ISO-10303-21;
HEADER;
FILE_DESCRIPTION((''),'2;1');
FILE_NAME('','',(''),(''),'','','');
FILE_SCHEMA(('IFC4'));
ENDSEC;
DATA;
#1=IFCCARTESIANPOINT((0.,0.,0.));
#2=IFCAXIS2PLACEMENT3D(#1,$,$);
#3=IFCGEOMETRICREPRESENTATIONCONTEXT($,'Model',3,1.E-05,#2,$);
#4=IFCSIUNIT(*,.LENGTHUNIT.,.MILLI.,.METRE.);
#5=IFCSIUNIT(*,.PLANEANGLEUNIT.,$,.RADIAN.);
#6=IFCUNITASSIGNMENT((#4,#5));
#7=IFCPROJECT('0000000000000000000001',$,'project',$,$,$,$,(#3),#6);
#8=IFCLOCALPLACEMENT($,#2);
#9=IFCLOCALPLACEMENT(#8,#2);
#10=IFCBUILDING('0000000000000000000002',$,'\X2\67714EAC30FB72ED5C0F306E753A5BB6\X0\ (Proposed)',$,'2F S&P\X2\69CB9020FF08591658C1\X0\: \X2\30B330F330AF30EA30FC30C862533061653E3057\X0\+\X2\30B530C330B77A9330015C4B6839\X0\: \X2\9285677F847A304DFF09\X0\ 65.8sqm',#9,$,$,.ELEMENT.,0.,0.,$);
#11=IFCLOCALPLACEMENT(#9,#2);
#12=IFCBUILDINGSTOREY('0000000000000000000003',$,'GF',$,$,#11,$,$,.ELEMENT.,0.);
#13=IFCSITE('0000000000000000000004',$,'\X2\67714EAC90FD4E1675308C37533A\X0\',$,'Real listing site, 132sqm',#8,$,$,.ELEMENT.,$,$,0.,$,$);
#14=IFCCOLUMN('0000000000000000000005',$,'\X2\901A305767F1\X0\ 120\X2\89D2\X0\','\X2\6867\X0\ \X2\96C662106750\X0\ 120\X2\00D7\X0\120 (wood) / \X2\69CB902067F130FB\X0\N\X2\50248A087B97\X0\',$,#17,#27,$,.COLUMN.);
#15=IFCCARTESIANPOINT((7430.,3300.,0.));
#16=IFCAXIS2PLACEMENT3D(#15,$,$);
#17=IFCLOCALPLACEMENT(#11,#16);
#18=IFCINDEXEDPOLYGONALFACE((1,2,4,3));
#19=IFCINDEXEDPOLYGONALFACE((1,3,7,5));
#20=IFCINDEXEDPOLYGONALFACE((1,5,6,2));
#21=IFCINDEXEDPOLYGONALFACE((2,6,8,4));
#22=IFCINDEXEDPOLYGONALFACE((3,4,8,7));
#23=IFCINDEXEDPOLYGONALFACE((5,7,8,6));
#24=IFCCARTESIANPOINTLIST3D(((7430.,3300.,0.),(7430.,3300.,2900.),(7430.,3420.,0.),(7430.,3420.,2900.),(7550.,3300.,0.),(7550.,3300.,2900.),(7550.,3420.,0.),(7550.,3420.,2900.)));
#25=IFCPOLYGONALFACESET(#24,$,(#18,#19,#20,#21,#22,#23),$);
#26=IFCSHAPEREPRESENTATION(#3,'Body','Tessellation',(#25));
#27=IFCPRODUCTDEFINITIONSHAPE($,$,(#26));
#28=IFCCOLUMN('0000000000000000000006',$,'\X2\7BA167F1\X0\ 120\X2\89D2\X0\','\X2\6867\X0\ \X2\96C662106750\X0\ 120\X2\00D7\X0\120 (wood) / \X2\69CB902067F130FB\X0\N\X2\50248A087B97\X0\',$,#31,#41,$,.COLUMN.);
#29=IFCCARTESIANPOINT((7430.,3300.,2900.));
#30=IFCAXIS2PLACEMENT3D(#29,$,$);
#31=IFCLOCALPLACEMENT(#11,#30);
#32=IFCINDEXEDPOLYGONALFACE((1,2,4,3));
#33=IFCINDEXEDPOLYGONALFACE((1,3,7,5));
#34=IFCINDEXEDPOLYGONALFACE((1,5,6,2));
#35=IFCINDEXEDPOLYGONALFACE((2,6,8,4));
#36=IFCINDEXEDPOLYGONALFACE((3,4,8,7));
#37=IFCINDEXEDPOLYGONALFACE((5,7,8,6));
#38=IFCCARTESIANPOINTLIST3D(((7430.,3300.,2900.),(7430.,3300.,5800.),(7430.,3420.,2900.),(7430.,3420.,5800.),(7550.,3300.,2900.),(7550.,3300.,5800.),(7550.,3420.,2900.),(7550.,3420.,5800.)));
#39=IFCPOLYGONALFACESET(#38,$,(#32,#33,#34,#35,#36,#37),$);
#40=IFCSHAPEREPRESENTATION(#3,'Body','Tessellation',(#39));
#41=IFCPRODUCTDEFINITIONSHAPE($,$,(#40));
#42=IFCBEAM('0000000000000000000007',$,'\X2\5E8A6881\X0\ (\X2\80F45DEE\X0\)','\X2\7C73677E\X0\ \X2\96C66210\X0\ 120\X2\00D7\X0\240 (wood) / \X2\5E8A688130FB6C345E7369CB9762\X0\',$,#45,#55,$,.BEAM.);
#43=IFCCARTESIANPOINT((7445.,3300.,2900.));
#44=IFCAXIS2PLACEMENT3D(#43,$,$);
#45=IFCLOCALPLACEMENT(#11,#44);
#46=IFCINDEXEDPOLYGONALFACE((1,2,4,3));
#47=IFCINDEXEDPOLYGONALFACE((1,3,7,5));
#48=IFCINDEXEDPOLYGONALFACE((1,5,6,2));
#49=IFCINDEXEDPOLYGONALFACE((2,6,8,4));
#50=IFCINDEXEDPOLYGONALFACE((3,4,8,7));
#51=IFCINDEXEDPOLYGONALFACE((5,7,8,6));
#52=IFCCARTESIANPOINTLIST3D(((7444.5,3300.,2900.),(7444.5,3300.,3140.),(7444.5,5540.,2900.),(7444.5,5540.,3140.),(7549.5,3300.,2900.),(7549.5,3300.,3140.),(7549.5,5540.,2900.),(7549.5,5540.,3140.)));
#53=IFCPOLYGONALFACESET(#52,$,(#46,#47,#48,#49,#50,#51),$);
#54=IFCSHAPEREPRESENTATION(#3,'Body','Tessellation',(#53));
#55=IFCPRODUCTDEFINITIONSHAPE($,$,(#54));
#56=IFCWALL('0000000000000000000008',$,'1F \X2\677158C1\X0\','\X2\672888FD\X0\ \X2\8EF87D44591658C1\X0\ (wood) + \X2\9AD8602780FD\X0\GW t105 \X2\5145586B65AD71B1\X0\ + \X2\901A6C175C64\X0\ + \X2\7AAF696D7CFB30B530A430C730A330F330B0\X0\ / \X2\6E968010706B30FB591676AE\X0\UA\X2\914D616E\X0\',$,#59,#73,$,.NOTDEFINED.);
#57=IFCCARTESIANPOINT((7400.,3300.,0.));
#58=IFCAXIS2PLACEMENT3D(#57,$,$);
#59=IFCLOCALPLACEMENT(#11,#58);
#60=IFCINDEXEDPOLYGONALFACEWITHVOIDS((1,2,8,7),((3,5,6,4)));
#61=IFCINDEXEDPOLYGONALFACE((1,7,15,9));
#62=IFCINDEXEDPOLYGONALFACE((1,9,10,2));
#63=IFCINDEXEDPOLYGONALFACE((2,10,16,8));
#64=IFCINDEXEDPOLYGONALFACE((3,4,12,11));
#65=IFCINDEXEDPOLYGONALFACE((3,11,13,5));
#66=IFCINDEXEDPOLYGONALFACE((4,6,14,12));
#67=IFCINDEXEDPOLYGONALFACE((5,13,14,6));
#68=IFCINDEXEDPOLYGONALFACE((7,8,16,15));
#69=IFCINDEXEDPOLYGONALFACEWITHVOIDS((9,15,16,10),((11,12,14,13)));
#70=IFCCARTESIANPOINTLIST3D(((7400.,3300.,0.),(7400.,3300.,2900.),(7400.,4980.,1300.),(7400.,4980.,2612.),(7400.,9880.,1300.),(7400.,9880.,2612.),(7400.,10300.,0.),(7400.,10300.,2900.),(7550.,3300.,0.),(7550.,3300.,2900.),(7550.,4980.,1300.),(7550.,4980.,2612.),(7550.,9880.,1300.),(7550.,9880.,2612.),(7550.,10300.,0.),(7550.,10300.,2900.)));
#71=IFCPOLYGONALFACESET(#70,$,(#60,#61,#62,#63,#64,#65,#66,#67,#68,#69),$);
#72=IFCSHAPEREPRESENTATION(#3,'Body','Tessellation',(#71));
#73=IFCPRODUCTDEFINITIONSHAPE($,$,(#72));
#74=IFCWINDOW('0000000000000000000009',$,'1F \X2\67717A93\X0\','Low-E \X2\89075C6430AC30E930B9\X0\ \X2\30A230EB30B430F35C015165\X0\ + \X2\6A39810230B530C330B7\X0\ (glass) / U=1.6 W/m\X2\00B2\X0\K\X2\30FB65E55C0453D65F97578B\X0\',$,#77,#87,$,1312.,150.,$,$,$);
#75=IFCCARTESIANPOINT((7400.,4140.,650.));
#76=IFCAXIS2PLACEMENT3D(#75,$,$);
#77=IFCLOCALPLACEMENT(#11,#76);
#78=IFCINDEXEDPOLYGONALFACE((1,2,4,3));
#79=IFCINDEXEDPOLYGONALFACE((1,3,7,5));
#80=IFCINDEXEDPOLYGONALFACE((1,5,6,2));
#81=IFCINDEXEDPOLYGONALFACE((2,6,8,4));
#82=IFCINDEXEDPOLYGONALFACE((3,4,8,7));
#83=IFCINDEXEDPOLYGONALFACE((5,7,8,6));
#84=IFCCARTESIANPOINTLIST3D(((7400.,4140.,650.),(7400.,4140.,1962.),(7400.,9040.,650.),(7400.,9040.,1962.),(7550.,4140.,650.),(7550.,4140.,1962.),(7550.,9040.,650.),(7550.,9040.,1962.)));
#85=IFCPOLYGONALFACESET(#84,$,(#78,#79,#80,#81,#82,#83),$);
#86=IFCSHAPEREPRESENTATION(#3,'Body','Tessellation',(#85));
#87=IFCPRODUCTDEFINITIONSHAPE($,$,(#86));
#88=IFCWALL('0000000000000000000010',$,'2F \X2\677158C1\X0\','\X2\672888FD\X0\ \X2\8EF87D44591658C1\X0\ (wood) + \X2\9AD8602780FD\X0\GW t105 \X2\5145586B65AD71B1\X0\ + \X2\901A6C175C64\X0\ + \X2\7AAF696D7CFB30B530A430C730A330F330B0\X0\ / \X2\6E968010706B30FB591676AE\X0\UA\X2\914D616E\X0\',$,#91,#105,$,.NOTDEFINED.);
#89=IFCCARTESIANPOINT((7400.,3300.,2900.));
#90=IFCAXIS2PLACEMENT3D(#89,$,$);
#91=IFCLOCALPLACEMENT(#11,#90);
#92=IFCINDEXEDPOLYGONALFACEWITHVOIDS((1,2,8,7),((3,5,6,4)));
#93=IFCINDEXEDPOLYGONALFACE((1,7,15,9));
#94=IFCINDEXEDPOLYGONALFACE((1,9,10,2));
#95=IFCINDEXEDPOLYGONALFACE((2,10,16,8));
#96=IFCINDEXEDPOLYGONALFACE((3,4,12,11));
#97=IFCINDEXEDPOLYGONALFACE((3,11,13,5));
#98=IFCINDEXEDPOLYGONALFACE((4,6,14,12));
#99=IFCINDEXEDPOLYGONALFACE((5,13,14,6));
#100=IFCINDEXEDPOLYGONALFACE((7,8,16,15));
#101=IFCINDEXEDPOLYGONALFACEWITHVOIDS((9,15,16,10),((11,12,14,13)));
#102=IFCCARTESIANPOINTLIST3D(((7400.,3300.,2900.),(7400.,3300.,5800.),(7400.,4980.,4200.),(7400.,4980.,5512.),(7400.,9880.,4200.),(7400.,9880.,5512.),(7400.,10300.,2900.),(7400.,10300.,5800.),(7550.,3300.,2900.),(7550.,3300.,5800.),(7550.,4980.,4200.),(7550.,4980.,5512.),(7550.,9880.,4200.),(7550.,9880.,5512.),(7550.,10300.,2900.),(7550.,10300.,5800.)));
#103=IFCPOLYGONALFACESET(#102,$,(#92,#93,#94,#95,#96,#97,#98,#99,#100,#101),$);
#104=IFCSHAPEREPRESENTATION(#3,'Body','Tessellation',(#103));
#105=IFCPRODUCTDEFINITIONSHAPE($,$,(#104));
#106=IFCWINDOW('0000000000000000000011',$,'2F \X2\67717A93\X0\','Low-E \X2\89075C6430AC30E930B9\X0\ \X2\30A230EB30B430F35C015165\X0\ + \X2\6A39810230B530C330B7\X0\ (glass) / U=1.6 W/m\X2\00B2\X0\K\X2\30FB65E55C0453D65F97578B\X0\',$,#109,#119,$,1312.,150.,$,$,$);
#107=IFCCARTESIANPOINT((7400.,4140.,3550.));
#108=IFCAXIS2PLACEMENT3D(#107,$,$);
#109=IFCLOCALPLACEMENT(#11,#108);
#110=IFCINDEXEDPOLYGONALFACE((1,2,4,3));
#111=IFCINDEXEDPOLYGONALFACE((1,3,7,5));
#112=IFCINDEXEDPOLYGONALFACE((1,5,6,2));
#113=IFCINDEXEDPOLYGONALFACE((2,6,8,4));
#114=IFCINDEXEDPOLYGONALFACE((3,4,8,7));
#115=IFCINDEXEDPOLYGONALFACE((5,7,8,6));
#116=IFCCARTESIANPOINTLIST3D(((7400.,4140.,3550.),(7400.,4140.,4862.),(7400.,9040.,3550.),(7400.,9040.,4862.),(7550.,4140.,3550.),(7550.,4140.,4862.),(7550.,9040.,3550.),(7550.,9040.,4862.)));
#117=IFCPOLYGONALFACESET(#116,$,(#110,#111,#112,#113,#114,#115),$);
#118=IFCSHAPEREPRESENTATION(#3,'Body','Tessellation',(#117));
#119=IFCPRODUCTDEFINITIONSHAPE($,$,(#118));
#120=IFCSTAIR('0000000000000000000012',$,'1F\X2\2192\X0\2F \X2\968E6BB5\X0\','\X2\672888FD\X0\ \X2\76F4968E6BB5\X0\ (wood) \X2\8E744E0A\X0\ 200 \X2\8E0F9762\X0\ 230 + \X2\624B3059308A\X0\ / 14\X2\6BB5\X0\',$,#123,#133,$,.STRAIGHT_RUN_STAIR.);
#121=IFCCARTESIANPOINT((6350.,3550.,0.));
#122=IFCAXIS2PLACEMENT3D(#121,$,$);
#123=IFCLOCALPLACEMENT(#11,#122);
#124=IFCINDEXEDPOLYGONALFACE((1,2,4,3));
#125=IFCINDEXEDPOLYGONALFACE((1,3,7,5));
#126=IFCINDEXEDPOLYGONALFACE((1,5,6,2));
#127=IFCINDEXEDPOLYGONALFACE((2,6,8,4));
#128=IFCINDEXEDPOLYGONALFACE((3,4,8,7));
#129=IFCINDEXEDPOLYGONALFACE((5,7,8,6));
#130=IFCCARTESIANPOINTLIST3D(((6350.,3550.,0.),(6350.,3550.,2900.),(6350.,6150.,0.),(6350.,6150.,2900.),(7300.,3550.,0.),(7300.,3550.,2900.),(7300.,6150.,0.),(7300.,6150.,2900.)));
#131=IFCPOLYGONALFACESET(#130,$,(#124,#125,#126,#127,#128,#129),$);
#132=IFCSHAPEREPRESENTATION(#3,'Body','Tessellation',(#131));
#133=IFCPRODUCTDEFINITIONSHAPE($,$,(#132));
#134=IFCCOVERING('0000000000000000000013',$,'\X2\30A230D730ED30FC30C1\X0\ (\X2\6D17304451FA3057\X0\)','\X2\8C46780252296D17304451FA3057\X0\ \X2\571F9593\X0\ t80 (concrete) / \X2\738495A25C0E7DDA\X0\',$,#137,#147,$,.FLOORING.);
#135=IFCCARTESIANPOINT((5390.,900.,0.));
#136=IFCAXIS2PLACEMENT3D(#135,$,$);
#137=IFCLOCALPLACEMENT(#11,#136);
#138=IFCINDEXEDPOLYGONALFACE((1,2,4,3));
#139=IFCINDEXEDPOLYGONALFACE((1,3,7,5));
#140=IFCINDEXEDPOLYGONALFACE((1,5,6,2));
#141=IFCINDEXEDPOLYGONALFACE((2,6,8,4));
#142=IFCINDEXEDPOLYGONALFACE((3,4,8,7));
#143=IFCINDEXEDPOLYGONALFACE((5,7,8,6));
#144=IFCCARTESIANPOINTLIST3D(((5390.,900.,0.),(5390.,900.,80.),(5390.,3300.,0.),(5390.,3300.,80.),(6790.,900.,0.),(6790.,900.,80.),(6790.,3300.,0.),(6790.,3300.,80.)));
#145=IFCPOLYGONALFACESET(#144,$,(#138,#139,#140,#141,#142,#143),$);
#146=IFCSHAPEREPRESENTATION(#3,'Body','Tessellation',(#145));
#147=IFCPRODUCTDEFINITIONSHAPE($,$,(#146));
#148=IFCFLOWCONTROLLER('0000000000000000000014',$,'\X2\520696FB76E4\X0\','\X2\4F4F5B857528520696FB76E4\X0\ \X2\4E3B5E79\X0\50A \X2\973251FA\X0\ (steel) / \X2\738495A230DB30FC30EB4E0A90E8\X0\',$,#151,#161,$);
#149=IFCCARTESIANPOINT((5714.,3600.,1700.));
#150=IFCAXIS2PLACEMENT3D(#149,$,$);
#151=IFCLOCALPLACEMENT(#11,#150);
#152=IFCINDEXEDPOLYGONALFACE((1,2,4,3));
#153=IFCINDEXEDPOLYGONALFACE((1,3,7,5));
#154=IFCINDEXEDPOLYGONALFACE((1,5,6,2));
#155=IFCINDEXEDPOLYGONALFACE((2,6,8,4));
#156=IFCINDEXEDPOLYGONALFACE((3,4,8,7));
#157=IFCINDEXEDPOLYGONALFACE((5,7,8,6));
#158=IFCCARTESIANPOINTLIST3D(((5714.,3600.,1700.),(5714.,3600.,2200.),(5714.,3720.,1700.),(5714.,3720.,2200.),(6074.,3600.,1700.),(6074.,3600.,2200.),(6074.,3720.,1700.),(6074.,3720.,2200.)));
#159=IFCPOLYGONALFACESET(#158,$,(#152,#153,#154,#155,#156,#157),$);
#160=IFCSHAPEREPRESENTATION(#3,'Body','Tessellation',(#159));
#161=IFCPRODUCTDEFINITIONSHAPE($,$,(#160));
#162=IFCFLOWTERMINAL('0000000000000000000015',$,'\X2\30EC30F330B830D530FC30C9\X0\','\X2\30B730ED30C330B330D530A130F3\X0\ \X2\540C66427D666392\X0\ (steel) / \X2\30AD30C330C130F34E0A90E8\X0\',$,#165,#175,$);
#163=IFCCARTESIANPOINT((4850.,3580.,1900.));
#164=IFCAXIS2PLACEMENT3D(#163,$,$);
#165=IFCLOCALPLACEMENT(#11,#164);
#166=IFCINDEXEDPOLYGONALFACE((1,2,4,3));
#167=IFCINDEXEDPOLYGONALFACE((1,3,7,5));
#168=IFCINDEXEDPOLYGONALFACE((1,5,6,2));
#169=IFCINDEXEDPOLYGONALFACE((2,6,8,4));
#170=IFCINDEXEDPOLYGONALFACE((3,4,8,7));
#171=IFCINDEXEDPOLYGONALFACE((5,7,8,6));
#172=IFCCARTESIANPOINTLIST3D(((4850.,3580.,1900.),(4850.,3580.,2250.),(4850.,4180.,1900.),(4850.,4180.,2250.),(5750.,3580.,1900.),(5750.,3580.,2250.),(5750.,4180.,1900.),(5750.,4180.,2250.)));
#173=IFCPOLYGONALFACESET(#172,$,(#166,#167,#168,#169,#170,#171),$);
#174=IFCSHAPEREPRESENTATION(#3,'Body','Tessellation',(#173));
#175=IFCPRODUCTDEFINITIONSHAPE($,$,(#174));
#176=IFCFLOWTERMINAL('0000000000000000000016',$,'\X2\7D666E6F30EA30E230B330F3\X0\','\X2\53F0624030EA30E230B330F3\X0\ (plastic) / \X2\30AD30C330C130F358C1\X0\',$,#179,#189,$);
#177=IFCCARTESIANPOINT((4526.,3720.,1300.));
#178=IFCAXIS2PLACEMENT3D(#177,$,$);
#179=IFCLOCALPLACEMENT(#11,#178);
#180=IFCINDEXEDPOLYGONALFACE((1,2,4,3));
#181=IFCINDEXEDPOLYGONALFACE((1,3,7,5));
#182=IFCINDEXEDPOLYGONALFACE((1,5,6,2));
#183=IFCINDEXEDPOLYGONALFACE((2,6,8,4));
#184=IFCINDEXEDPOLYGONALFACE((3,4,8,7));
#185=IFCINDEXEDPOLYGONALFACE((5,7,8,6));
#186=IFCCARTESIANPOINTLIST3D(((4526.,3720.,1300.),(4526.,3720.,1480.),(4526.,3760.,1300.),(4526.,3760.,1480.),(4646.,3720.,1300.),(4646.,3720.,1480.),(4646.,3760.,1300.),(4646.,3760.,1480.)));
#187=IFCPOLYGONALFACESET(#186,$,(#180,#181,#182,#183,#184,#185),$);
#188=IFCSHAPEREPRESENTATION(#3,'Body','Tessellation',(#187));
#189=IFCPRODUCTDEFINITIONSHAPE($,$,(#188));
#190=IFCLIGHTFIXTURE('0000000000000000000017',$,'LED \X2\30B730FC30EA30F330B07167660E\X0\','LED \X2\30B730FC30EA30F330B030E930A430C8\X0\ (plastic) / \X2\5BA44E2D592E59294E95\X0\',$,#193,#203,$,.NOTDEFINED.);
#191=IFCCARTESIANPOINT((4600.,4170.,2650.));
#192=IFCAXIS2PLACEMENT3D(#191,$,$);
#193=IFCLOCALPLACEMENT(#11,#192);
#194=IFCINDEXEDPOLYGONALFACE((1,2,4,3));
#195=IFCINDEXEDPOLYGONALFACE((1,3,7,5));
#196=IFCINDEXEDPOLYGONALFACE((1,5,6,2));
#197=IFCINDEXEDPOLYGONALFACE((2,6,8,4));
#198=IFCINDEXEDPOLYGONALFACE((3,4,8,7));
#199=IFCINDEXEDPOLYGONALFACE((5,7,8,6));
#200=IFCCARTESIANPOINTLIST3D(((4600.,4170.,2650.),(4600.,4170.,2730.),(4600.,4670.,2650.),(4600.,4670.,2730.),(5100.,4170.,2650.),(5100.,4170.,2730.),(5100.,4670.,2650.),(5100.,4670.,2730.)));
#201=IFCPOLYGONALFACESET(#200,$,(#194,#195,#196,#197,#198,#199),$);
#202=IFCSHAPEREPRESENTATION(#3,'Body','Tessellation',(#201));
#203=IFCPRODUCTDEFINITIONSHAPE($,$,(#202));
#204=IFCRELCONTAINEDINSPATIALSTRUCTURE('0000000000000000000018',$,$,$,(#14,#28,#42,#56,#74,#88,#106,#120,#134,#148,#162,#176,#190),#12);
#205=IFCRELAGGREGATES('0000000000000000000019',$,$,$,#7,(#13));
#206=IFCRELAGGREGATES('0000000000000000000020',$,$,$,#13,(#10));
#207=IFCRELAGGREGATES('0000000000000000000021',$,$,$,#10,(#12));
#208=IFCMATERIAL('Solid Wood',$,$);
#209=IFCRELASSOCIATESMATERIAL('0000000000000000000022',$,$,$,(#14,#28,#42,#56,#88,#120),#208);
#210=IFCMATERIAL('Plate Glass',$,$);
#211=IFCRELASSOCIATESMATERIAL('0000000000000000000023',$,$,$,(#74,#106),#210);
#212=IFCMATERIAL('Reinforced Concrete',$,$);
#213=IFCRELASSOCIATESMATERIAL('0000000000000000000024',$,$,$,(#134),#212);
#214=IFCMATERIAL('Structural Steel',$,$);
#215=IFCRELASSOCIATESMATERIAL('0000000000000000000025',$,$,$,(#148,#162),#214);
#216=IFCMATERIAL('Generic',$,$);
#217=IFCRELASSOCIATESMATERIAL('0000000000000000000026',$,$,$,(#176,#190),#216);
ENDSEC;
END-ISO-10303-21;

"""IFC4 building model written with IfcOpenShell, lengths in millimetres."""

from ifc_helpers import new_model, si_unit, frame, frame_2d, origin, place, context, project, spatial, rectangle, extrude, material, element, fill, save


model = new_model("IFC4")

# Units and contexts
model_context = context("Model", 3, precision=1e-05, world=origin())
ifc_project = project(units=[si_unit("LENGTHUNIT", "METRE", prefix="MILLI"), si_unit("PLANEANGLEUNIT", "RADIAN")], contexts=[model_context])

# Site, building, storey
site_placement = place(None, origin())
site = spatial("IfcSite", under=ifc_project, at=site_placement, Name="東京都世田谷区", ObjectType="Real listing site, 132sqm", CompositionType="ELEMENT", RefElevation=0.0)
building_placement = place(site_placement, origin())
building = spatial("IfcBuilding", under=site, at=building_placement, Name="東京・狭小の町家 (Proposed)", ObjectType="2F S&P構造（外壁: コンクリート打ち放し+サッシ窓、屋根: 銅板葺き） 65.8sqm", CompositionType="ELEMENT", ElevationOfRefHeight=0.0, ElevationOfTerrain=0.0)
storey_placement = place(building_placement, origin())
storey = spatial("IfcBuildingStorey", under=building, at=storey_placement, Name="GF", CompositionType="ELEMENT", Elevation=0.0)

# Columns
ifc_material_1 = material(Name="Solid Wood")
column_1_placement = place(storey_placement, frame((7430.0, 3300.0, 0.0)))
element("IfcColumn", 1, at=column_1_placement, inside=storey, material=ifc_material_1, Name="通し柱 120角", Description="桧 集成材 120×120 (wood) / 構造柱・N値計算", PredefinedType="COLUMN", context=model_context, shape_type="SweptSolid", body=[
    extrude(rectangle(XDim=120.0, YDim=120.0, at=frame_2d((60.0, 60.0))), frame((7430.0, 3300.0, 0.0)), (0.0, 0.0, 1.0), 2900.0),
])
column_2_placement = place(storey_placement, frame((7430.0, 3300.0, 2900.0)))
element("IfcColumn", 2, at=column_2_placement, inside=storey, material=ifc_material_1, Name="管柱 120角", Description="桧 集成材 120×120 (wood) / 構造柱・N値計算", PredefinedType="COLUMN", context=model_context, shape_type="SweptSolid", body=[
    extrude(rectangle(XDim=120.0, YDim=120.0, at=frame_2d((60.0, 60.0))), frame((7430.0, 3300.0, 2900.0)), (0.0, 0.0, 1.0), 2900.0),
])

# Beam
beam_1_placement = place(storey_placement, frame((7445.0, 3300.0, 2900.0)))
element("IfcBeam", 3, at=beam_1_placement, inside=storey, material=ifc_material_1, Name="床梁 (胴差)", Description="米松 集成 120×240 (wood) / 床梁・水平構面", PredefinedType="BEAM", context=model_context, shape_type="SweptSolid", body=[
    extrude(rectangle(XDim=105.0, YDim=2240.0, at=frame_2d((52.0, 1120.0))), frame((7445.0, 3300.0, 2900.0)), (0.0, 0.0, 1.0), 240.0),
])

# Wall, opening, window
wall_1_placement = place(storey_placement, frame((7400.0, 3300.0, 0.0)))
wall_1 = element("IfcWall", 4, at=wall_1_placement, inside=storey, material=ifc_material_1, Name="1F 東壁", Description="木製 軸組外壁 (wood) + 高性能GW t105 充填断熱 + 通気層 + 窯業系サイディング / 準耐火・外皮UA配慮", PredefinedType="NOTDEFINED", context=model_context, shape_type="SweptSolid", body=[
    extrude(rectangle(XDim=150.0, YDim=7000.0, at=frame_2d((75.0, 3500.0))), frame((7400.0, 3300.0, 0.0)), (0.0, 0.0, 1.0), 2900.0),
])
opening_1_placement = place(storey_placement, frame((7400.0, 4140.0, 650.0)))
opening_1 = element("IfcOpeningElement", 5, at=opening_1_placement, cuts=wall_1, PredefinedType="NOTDEFINED", context=model_context, shape_type="SweptSolid", body=[
    extrude(rectangle(XDim=150.0, YDim=4900.0, at=frame_2d((75.0, 2450.0))), frame((7400.0, 4140.0, 650.0)), (0.0, 0.0, 1.0), 1312.0),
])
ifc_material_2 = material(Name="Plate Glass")
window_1_placement = place(storey_placement, frame((7400.0, 4140.0, 650.0)))
window_1 = element("IfcWindow", 6, at=window_1_placement, inside=storey, material=ifc_material_2, Name="1F 東窓", Description="Low-E 複層ガラス アルゴン封入 + 樹脂サッシ (glass) / U=1.6 W/m²K・日射取得型", OverallHeight=1312.0, OverallWidth=150.0, context=model_context, shape_type="SweptSolid", body=[
    extrude(rectangle(XDim=150.0, YDim=4900.0, at=frame_2d((75.0, 2450.0))), frame((7400.0, 4140.0, 650.0)), (0.0, 0.0, 1.0), 1312.0),
])
fill(opening_1, window_1)

# Wall, opening, window
wall_2_placement = place(storey_placement, frame((7400.0, 3300.0, 2900.0)))
wall_2 = element("IfcWall", 7, at=wall_2_placement, inside=storey, material=ifc_material_1, Name="2F 東壁", Description="木製 軸組外壁 (wood) + 高性能GW t105 充填断熱 + 通気層 + 窯業系サイディング / 準耐火・外皮UA配慮", PredefinedType="NOTDEFINED", context=model_context, shape_type="SweptSolid", body=[
    extrude(rectangle(XDim=150.0, YDim=7000.0, at=frame_2d((75.0, 3500.0))), frame((7400.0, 3300.0, 2900.0)), (0.0, 0.0, 1.0), 2900.0),
])
opening_2_placement = place(storey_placement, frame((7400.0, 4140.0, 3550.0)))
opening_2 = element("IfcOpeningElement", 8, at=opening_2_placement, cuts=wall_2, PredefinedType="NOTDEFINED", context=model_context, shape_type="SweptSolid", body=[
    extrude(rectangle(XDim=150.0, YDim=4900.0, at=frame_2d((75.0, 2450.0))), frame((7400.0, 4140.0, 3550.0)), (0.0, 0.0, 1.0), 1312.0),
])
window_2_placement = place(storey_placement, frame((7400.0, 4140.0, 3550.0)))
window_2 = element("IfcWindow", 9, at=window_2_placement, inside=storey, material=ifc_material_2, Name="2F 東窓", Description="Low-E 複層ガラス アルゴン封入 + 樹脂サッシ (glass) / U=1.6 W/m²K・日射取得型", OverallHeight=1312.0, OverallWidth=150.0, context=model_context, shape_type="SweptSolid", body=[
    extrude(rectangle(XDim=150.0, YDim=4900.0, at=frame_2d((75.0, 2450.0))), frame((7400.0, 4140.0, 3550.0)), (0.0, 0.0, 1.0), 1312.0),
])
fill(opening_2, window_2)

# Stair
stair_placement = place(storey_placement, frame((6350.0, 3550.0, 0.0)))
element("IfcStair", 10, at=stair_placement, inside=storey, material=ifc_material_1, Name="1F→2F 階段", Description="木製 直階段 (wood) 蹴上 200 踏面 230 + 手すり / 14段", PredefinedType="STRAIGHT_RUN_STAIR", context=model_context, shape_type="SweptSolid", body=[
    extrude(rectangle(XDim=950.0, YDim=2600.0, at=frame_2d((475.0, 1300.0))), frame((6350.0, 3550.0, 0.0)), (0.0, 0.0, 1.0), 2900.0),
])

# Covering
ifc_material_3 = material(Name="Reinforced Concrete")
covering_placement = place(storey_placement, frame((5390.0, 900.0, 0.0)))
element("IfcCovering", 11, at=covering_placement, inside=storey, material=ifc_material_3, Name="アプローチ (洗い出し)", Description="豆砂利洗い出し 土間 t80 (concrete) / 玄関導線", PredefinedType="FLOORING", context=model_context, shape_type="SweptSolid", body=[
    extrude(rectangle(XDim=1400.0, YDim=2400.0, at=frame_2d((700.0, 1200.0))), frame((5390.0, 900.0, 0.0)), (0.0, 0.0, 1.0), 80.0),
])

# Flow controller
ifc_material_4 = material(Name="Structural Steel")
flow_controller_placement = place(storey_placement, frame((5714.0, 3600.0, 1700.0)))
element("IfcFlowController", 12, at=flow_controller_placement, inside=storey, material=ifc_material_4, Name="分電盤", Description="住宅用分電盤 主幹50A 露出 (steel) / 玄関ホール上部", context=model_context, shape_type="SweptSolid", body=[
    extrude(rectangle(XDim=360.0, YDim=120.0, at=frame_2d((180.0, 60.0))), frame((5714.0, 3600.0, 1700.0)), (0.0, 0.0, 1.0), 500.0),
])

# Flow terminals
flow_terminal_1_placement = place(storey_placement, frame((4850.0, 3580.0, 1900.0)))
element("IfcFlowTerminal", 13, at=flow_terminal_1_placement, inside=storey, material=ifc_material_4, Name="レンジフード", Description="シロッコファン 同時給排 (steel) / キッチン上部", context=model_context, shape_type="SweptSolid", body=[
    extrude(rectangle(XDim=900.0, YDim=600.0, at=frame_2d((450.0, 300.0))), frame((4850.0, 3580.0, 1900.0)), (0.0, 0.0, 1.0), 350.0),
])
ifc_material_5 = material(Name="Generic")
flow_terminal_2_placement = place(storey_placement, frame((4526.0, 3720.0, 1300.0)))
element("IfcFlowTerminal", 14, at=flow_terminal_2_placement, inside=storey, material=ifc_material_5, Name="給湯リモコン", Description="台所リモコン (plastic) / キッチン壁", context=model_context, shape_type="SweptSolid", body=[
    extrude(rectangle(XDim=120.0, YDim=40.0, at=frame_2d((60.0, 20.0))), frame((4526.0, 3720.0, 1300.0)), (0.0, 0.0, 1.0), 180.0),
])

# Light fixture
light_fixture_1_placement = place(storey_placement, frame((4600.0, 4170.0, 2650.0)))
element("IfcLightFixture", 15, at=light_fixture_1_placement, inside=storey, material=ifc_material_5, Name="LED シーリング照明", Description="LED シーリングライト (plastic) / 室中央天井", PredefinedType="NOTDEFINED", context=model_context, shape_type="SweptSolid", body=[
    extrude(rectangle(XDim=500.0, YDim=500.0, at=frame_2d((250.0, 250.0))), frame((4600.0, 4170.0, 2650.0)), (0.0, 0.0, 1.0), 80.0),
])

save(model, "model.ifc")
